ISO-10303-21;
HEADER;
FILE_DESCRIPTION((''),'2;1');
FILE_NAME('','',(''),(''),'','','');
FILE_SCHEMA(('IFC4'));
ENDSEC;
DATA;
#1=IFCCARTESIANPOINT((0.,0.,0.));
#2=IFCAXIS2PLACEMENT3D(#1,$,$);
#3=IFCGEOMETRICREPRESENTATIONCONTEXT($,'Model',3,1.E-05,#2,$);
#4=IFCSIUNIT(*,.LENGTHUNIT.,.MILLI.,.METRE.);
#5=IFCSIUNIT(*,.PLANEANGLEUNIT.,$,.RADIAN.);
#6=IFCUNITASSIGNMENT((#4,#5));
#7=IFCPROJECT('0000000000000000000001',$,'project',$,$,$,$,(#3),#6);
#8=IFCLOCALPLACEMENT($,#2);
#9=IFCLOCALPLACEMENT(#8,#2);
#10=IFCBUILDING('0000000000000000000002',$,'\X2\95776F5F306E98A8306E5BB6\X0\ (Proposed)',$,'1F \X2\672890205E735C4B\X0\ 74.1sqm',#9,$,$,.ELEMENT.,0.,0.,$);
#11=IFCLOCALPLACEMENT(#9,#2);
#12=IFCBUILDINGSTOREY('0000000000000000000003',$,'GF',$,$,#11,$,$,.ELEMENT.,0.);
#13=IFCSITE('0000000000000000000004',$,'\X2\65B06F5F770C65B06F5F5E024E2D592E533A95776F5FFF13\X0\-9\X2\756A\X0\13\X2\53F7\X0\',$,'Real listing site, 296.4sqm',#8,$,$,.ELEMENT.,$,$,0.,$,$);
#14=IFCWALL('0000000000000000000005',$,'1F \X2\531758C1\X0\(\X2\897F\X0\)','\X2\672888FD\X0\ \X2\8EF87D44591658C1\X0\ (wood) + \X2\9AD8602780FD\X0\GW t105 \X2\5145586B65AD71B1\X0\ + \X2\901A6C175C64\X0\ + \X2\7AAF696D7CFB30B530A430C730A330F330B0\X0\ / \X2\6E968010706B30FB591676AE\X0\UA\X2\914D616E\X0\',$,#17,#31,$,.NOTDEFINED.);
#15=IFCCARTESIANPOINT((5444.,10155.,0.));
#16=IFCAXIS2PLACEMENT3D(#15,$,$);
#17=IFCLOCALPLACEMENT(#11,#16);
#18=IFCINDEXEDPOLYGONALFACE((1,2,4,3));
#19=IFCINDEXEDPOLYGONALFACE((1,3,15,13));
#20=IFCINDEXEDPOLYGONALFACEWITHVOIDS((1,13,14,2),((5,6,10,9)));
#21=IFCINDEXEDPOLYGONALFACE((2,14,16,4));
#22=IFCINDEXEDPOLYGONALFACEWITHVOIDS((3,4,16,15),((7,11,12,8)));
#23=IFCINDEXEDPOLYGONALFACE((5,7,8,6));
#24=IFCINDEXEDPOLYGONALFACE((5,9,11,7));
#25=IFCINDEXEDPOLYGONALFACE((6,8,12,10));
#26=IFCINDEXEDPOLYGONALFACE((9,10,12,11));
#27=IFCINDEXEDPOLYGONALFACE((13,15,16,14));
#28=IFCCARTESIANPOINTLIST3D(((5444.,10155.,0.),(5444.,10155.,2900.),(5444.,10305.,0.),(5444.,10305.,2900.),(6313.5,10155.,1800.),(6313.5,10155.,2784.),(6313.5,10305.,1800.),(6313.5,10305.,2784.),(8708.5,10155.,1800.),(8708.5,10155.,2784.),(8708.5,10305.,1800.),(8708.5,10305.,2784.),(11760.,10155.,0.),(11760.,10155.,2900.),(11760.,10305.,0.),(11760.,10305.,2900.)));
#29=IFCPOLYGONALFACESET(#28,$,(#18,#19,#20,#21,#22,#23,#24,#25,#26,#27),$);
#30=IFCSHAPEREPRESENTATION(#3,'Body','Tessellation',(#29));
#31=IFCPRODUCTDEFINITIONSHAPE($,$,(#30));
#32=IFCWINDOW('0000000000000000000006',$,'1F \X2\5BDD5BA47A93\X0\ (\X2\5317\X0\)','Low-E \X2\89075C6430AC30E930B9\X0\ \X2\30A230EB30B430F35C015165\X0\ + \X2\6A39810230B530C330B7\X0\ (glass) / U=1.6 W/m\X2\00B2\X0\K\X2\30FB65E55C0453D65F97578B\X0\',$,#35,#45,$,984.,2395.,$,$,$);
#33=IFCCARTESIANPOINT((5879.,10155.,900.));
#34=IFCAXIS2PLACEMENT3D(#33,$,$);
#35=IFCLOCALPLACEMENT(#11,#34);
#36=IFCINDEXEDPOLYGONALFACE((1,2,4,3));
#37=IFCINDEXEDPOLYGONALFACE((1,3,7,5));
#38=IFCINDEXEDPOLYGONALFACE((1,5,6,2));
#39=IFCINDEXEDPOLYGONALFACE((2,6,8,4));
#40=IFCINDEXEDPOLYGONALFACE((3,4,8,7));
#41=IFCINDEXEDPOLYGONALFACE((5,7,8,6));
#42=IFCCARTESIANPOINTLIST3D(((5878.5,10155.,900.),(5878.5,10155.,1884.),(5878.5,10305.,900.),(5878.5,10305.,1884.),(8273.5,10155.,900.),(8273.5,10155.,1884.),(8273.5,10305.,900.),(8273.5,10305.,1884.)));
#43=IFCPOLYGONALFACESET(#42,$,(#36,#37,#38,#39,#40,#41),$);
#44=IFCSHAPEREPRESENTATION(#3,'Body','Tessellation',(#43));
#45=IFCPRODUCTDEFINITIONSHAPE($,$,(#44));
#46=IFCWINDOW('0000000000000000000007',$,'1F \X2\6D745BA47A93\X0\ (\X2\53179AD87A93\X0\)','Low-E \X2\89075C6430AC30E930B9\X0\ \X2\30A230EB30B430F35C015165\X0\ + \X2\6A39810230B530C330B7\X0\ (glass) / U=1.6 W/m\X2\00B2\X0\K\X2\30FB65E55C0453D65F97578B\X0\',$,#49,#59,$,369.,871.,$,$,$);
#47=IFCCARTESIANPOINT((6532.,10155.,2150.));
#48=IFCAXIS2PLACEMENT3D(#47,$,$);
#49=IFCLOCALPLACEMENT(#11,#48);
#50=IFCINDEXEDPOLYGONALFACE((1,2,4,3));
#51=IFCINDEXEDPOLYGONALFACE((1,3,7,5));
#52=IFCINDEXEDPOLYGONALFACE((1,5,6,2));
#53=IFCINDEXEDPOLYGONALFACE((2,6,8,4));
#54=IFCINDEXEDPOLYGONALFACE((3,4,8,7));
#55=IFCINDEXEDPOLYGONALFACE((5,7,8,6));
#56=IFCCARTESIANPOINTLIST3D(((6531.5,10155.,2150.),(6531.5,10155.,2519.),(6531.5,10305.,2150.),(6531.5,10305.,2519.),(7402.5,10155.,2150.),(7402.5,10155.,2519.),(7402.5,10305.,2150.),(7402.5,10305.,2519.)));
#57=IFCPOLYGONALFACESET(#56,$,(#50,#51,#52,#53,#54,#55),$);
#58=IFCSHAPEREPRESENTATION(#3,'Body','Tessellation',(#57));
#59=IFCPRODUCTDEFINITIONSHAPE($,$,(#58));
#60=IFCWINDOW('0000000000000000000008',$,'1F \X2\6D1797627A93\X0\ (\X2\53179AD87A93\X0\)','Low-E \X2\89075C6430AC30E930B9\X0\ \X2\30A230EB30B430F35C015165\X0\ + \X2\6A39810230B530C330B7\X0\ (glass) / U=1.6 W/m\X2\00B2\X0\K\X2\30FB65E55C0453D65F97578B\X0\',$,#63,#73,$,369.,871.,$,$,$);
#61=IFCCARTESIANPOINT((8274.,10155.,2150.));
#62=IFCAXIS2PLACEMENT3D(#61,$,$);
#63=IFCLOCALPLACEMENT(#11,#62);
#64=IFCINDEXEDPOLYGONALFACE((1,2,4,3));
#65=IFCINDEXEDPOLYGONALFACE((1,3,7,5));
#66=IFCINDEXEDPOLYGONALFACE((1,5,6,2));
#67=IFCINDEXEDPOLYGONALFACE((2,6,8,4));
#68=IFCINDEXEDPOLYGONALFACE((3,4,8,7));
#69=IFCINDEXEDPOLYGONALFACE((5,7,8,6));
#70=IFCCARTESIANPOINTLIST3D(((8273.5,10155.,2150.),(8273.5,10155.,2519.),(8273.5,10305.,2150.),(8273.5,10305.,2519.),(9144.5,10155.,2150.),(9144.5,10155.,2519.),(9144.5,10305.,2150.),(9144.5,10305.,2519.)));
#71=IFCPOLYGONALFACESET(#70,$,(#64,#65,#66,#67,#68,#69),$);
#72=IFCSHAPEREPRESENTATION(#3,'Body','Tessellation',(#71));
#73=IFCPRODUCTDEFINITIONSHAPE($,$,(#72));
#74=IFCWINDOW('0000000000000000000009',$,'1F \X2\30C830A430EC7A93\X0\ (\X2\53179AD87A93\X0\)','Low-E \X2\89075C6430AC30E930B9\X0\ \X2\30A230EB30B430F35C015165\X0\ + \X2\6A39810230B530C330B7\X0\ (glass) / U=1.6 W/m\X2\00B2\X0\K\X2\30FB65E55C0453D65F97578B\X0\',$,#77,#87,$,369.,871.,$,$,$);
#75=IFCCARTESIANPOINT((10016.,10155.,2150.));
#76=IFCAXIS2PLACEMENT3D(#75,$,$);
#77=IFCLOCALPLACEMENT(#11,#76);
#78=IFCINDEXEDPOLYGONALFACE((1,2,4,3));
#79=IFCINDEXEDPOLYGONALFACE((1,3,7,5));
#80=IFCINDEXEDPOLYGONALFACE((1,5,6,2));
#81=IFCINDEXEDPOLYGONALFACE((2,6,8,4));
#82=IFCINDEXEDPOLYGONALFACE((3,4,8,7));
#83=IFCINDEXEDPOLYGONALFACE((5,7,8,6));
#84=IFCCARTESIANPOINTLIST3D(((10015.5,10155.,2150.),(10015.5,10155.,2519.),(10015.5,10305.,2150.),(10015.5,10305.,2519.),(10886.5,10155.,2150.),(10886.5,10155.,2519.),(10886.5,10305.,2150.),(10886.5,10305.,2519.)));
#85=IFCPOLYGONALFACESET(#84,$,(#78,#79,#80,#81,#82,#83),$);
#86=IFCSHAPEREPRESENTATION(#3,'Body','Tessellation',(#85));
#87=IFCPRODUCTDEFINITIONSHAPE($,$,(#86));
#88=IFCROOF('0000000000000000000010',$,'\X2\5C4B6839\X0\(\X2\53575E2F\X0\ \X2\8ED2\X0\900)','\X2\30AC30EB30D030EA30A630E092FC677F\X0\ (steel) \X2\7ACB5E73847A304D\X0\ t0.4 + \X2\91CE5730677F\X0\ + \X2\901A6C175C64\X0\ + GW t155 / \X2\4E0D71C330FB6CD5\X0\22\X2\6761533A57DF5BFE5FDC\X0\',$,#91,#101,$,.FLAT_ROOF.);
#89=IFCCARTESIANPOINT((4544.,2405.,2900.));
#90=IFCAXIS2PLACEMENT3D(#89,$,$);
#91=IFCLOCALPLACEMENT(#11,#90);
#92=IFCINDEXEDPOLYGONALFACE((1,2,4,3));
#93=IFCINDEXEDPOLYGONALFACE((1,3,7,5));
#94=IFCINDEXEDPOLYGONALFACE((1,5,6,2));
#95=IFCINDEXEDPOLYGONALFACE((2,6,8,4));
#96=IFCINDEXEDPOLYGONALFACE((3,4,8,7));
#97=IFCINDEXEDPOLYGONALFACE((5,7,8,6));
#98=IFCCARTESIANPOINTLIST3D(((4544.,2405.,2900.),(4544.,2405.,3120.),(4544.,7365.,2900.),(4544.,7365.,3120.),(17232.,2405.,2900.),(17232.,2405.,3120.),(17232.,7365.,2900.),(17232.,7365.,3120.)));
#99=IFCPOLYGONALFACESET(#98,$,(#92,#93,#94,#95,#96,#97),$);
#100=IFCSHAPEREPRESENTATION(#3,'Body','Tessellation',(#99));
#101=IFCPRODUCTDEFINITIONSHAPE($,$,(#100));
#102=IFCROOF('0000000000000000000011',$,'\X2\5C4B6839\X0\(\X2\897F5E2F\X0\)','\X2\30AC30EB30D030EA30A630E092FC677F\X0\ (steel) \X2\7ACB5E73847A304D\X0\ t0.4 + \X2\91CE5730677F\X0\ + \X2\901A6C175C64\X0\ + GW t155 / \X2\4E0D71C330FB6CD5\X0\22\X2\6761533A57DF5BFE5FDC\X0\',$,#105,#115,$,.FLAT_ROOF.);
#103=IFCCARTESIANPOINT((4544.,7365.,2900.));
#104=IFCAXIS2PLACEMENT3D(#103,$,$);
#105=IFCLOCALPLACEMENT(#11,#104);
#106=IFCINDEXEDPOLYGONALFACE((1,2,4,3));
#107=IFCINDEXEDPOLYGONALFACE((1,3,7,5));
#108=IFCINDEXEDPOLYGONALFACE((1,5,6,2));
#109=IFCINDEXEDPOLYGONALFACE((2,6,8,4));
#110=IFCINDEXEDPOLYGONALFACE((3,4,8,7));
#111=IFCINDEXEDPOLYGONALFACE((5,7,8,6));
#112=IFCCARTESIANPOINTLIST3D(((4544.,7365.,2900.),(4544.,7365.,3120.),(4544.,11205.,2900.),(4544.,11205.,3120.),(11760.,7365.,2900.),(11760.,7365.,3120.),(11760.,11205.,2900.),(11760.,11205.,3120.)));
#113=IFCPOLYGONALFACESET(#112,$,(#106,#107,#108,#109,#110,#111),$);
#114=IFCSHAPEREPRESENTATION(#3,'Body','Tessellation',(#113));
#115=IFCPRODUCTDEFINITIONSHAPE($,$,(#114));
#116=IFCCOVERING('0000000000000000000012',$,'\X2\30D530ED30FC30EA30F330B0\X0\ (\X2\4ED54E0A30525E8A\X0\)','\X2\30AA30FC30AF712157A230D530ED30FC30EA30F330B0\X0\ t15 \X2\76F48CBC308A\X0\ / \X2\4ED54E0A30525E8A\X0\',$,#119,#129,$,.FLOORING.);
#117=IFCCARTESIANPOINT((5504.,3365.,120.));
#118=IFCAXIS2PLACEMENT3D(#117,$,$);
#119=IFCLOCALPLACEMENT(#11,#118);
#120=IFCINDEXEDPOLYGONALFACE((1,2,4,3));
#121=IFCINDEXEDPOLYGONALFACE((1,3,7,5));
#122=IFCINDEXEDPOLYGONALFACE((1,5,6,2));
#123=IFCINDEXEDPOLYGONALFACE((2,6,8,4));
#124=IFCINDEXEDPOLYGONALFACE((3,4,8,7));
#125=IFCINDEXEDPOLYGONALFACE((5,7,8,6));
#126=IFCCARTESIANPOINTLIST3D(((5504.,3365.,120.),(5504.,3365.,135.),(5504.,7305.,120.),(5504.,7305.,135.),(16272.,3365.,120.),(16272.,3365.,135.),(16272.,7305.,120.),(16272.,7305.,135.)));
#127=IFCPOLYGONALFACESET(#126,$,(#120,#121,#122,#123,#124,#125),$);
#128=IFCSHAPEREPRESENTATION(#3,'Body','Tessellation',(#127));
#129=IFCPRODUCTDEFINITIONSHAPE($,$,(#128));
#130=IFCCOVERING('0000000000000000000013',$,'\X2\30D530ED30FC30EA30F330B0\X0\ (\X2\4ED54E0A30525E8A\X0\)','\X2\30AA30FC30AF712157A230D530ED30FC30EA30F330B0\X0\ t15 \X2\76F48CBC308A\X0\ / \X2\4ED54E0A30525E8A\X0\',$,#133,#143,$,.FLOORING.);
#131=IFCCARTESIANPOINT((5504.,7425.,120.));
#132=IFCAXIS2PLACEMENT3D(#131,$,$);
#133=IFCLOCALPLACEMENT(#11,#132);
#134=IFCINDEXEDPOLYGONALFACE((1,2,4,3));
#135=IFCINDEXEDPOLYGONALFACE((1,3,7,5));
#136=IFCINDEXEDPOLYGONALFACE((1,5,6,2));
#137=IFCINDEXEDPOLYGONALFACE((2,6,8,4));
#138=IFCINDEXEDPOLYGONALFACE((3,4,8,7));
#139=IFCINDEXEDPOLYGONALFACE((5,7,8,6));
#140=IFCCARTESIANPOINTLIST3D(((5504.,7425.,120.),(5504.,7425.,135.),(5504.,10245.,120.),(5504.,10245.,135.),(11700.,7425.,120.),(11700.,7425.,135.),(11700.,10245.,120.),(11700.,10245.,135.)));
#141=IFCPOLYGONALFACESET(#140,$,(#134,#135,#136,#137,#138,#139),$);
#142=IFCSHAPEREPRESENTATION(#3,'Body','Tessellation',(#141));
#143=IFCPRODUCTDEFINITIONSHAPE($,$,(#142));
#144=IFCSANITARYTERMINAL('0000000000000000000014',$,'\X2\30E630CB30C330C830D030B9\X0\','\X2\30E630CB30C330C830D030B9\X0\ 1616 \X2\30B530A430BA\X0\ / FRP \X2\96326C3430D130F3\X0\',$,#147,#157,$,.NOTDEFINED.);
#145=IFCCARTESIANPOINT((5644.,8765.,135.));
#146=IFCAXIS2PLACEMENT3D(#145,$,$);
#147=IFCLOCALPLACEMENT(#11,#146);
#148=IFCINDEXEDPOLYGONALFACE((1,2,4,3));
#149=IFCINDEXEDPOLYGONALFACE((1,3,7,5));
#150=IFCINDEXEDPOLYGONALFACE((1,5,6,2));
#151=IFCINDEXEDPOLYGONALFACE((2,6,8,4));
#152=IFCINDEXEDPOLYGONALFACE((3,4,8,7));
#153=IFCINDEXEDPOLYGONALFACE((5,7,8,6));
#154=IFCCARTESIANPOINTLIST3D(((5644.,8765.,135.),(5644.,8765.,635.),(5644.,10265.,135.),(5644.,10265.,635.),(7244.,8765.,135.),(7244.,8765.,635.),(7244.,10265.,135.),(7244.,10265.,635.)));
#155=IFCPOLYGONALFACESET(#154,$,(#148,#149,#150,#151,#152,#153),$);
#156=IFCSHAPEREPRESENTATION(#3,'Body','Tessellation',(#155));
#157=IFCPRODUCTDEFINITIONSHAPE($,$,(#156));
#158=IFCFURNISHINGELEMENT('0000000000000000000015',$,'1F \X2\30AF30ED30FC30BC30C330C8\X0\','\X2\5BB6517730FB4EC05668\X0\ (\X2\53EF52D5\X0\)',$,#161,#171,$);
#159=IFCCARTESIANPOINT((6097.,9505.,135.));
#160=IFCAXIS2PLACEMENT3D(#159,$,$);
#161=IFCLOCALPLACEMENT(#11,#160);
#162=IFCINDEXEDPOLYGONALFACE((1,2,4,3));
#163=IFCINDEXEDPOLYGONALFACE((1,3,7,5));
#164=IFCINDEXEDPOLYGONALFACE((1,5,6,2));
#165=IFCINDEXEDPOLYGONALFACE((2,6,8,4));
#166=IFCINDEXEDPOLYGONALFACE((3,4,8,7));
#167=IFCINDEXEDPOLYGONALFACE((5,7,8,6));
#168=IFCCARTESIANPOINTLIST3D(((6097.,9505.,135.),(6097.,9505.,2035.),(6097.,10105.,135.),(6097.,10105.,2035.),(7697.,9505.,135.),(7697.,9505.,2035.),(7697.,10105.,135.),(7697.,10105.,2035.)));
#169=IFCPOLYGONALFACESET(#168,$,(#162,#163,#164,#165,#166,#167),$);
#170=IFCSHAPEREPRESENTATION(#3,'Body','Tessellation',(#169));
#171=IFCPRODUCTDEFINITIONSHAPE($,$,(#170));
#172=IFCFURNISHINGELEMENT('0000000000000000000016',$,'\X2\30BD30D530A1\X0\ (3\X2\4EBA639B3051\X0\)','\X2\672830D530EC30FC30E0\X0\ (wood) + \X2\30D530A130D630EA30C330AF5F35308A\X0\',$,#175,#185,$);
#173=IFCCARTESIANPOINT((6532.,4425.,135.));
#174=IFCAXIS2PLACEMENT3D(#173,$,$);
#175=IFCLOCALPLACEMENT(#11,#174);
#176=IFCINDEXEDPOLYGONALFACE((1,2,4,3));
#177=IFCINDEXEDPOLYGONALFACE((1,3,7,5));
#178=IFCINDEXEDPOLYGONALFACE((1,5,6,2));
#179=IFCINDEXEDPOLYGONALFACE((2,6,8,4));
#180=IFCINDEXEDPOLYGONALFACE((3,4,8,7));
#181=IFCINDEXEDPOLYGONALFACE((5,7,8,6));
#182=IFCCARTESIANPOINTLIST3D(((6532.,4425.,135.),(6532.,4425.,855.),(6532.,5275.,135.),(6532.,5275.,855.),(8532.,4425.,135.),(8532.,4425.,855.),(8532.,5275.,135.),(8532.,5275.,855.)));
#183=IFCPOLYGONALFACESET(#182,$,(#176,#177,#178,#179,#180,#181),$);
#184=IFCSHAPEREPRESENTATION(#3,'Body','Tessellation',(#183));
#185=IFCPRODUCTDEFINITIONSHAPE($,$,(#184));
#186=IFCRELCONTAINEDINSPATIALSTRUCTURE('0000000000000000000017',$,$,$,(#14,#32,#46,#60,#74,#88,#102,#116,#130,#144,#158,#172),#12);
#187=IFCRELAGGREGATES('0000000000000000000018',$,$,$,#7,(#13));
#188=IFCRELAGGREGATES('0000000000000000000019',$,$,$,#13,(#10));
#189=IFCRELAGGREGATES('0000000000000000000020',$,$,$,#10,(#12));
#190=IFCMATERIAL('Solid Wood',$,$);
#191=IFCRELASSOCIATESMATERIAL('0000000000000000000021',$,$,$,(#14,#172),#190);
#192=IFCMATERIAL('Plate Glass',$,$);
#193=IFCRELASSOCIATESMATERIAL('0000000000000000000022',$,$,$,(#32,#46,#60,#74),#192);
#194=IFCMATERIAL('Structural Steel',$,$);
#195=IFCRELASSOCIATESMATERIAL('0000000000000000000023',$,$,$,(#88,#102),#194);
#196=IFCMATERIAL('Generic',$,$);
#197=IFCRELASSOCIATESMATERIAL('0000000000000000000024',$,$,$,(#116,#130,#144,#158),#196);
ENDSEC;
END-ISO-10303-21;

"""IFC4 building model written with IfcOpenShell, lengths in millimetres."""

from ifc_helpers import new_model, si_unit, frame, frame_2d, origin, place, context, project, spatial, rectangle, extrude, material, element, fill, save


model = new_model("IFC4")

# Units and contexts
model_context = context("Model", 3, precision=1e-05, world=origin())
ifc_project = project(units=[si_unit("LENGTHUNIT", "METRE", prefix="MILLI"), si_unit("PLANEANGLEUNIT", "RADIAN")], contexts=[model_context])

# Site, building, storey
site_placement = place(None, origin())
site = spatial("IfcSite", under=ifc_project, at=site_placement, Name="新潟県新潟市中央区長潟３-9番13号", ObjectType="Real listing site, 296.4sqm", CompositionType="ELEMENT", RefElevation=0.0)
building_placement = place(site_placement, origin())
building = spatial("IfcBuilding", under=site, at=building_placement, Name="長潟の風の家 (Proposed)", ObjectType="1F 木造平屋 74.1sqm", CompositionType="ELEMENT", ElevationOfRefHeight=0.0, ElevationOfTerrain=0.0)
storey_placement = place(building_placement, origin())
storey = spatial("IfcBuildingStorey", under=building, at=storey_placement, Name="GF", CompositionType="ELEMENT", Elevation=0.0)

# Shared definitions
ifc_material_1 = material(Name="Solid Wood")

# Shared definitions
ifc_material_2 = material(Name="Plate Glass")

# Wall, openings, windows
wall_1_placement = place(storey_placement, frame((5444.0, 10155.0, 0.0)))
wall_1 = element("IfcWall", 1, at=wall_1_placement, inside=storey, material=ifc_material_1, Name="1F 北壁(西)", Description="木製 軸組外壁 (wood) + 高性能GW t105 充填断熱 + 通気層 + 窯業系サイディング / 準耐火・外皮UA配慮", PredefinedType="NOTDEFINED", context=model_context, shape_type="SweptSolid", body=[
    extrude(rectangle(XDim=6316.0, YDim=150.0, at=frame_2d((3158.0, 75.0))), frame((5444.0, 10155.0, 0.0)), (0.0, 0.0, 1.0), 2900.0),
])
opening_1_placement = place(storey_placement, frame((5879.0, 10155.0, 900.0)))
opening_1 = element("IfcOpeningElement", 2, at=opening_1_placement, cuts=wall_1, PredefinedType="NOTDEFINED", context=model_context, shape_type="SweptSolid", body=[
    extrude(rectangle(XDim=2395.0, YDim=150.0, at=frame_2d((1197.0, 75.0))), frame((5879.0, 10155.0, 900.0)), (0.0, 0.0, 1.0), 984.0),
])
opening_2_placement = place(storey_placement, frame((6532.0, 10155.0, 2150.0)))
opening_2 = element("IfcOpeningElement", 3, at=opening_2_placement, cuts=wall_1, PredefinedType="NOTDEFINED", context=model_context, shape_type="SweptSolid", body=[
    extrude(rectangle(XDim=871.0, YDim=150.0, at=frame_2d((435.0, 75.0))), frame((6532.0, 10155.0, 2150.0)), (0.0, 0.0, 1.0), 369.0),
])
opening_3_placement = place(storey_placement, frame((8274.0, 10155.0, 2150.0)))
opening_3 = element("IfcOpeningElement", 4, at=opening_3_placement, cuts=wall_1, PredefinedType="NOTDEFINED", context=model_context, shape_type="SweptSolid", body=[
    extrude(rectangle(XDim=871.0, YDim=150.0, at=frame_2d((435.0, 75.0))), frame((8274.0, 10155.0, 2150.0)), (0.0, 0.0, 1.0), 369.0),
])
opening_4_placement = place(storey_placement, frame((10016.0, 10155.0, 2150.0)))
opening_4 = element("IfcOpeningElement", 5, at=opening_4_placement, cuts=wall_1, PredefinedType="NOTDEFINED", context=model_context, shape_type="SweptSolid", body=[
    extrude(rectangle(XDim=871.0, YDim=150.0, at=frame_2d((435.0, 75.0))), frame((10016.0, 10155.0, 2150.0)), (0.0, 0.0, 1.0), 369.0),
])
window_1_placement = place(storey_placement, frame((5879.0, 10155.0, 900.0)))
window_1 = element("IfcWindow", 6, at=window_1_placement, inside=storey, material=ifc_material_2, Name="1F 寝室窓 (北)", Description="Low-E 複層ガラス アルゴン封入 + 樹脂サッシ (glass) / U=1.6 W/m²K・日射取得型", OverallHeight=984.0, OverallWidth=2395.0, context=model_context, shape_type="SweptSolid", body=[
    extrude(rectangle(XDim=2395.0, YDim=150.0, at=frame_2d((1197.0, 75.0))), frame((5879.0, 10155.0, 900.0)), (0.0, 0.0, 1.0), 984.0),
])
fill(opening_1, window_1)
window_2_placement = place(storey_placement, frame((6532.0, 10155.0, 2150.0)))
window_2 = element("IfcWindow", 7, at=window_2_placement, inside=storey, material=ifc_material_2, Name="1F 浴室窓 (北高窓)", Description="Low-E 複層ガラス アルゴン封入 + 樹脂サッシ (glass) / U=1.6 W/m²K・日射取得型", OverallHeight=369.0, OverallWidth=871.0, context=model_context, shape_type="SweptSolid", body=[
    extrude(rectangle(XDim=871.0, YDim=150.0, at=frame_2d((435.0, 75.0))), frame((6532.0, 10155.0, 2150.0)), (0.0, 0.0, 1.0), 369.0),
])
fill(opening_2, window_2)
window_3_placement = place(storey_placement, frame((8274.0, 10155.0, 2150.0)))
window_3 = element("IfcWindow", 8, at=window_3_placement, inside=storey, material=ifc_material_2, Name="1F 洗面窓 (北高窓)", Description="Low-E 複層ガラス アルゴン封入 + 樹脂サッシ (glass) / U=1.6 W/m²K・日射取得型", OverallHeight=369.0, OverallWidth=871.0, context=model_context, shape_type="SweptSolid", body=[
    extrude(rectangle(XDim=871.0, YDim=150.0, at=frame_2d((435.0, 75.0))), frame((8274.0, 10155.0, 2150.0)), (0.0, 0.0, 1.0), 369.0),
])
fill(opening_3, window_3)
window_4_placement = place(storey_placement, frame((10016.0, 10155.0, 2150.0)))
window_4 = element("IfcWindow", 9, at=window_4_placement, inside=storey, material=ifc_material_2, Name="1F トイレ窓 (北高窓)", Description="Low-E 複層ガラス アルゴン封入 + 樹脂サッシ (glass) / U=1.6 W/m²K・日射取得型", OverallHeight=369.0, OverallWidth=871.0, context=model_context, shape_type="SweptSolid", body=[
    extrude(rectangle(XDim=871.0, YDim=150.0, at=frame_2d((435.0, 75.0))), frame((10016.0, 10155.0, 2150.0)), (0.0, 0.0, 1.0), 369.0),
])
fill(opening_4, window_4)

# Roofs
ifc_material_3 = material(Name="Structural Steel")
roof_1_placement = place(storey_placement, frame((4544.0, 2405.0, 2900.0)))
element("IfcRoof", 10, at=roof_1_placement, inside=storey, material=ifc_material_3, Name="屋根(南帯 軒900)", Description="ガルバリウム鋼板 (steel) 立平葺き t0.4 + 野地板 + 通気層 + GW t155 / 不燃・法22条区域対応", PredefinedType="FLAT_ROOF", context=model_context, shape_type="SweptSolid", body=[
    extrude(rectangle(XDim=12688.0, YDim=4960.0, at=frame_2d((6344.0, 2480.0))), frame((4544.0, 2405.0, 2900.0)), (0.0, 0.0, 1.0), 220.0),
])
roof_2_placement = place(storey_placement, frame((4544.0, 7365.0, 2900.0)))
element("IfcRoof", 11, at=roof_2_placement, inside=storey, material=ifc_material_3, Name="屋根(西帯)", Description="ガルバリウム鋼板 (steel) 立平葺き t0.4 + 野地板 + 通気層 + GW t155 / 不燃・法22条区域対応", PredefinedType="FLAT_ROOF", context=model_context, shape_type="SweptSolid", body=[
    extrude(rectangle(XDim=7216.0, YDim=3840.0, at=frame_2d((3608.0, 1920.0))), frame((4544.0, 7365.0, 2900.0)), (0.0, 0.0, 1.0), 220.0),
])

# Coverings
ifc_material_4 = material(Name="Generic")
covering_1_placement = place(storey_placement, frame((5504.0, 3365.0, 120.0)))
element("IfcCovering", 12, at=covering_1_placement, inside=storey, material=ifc_material_4, Name="フローリング (仕上げ床)", Description="オーク無垢フローリング t15 直貼り / 仕上げ床", PredefinedType="FLOORING", context=model_context, shape_type="SweptSolid", body=[
    extrude(rectangle(XDim=10768.0, YDim=3940.0, at=frame_2d((5384.0, 1970.0))), frame((5504.0, 3365.0, 120.0)), (0.0, 0.0, 1.0), 15.0),
])
covering_2_placement = place(storey_placement, frame((5504.0, 7425.0, 120.0)))
element("IfcCovering", 13, at=covering_2_placement, inside=storey, material=ifc_material_4, Name="フローリング (仕上げ床)", Description="オーク無垢フローリング t15 直貼り / 仕上げ床", PredefinedType="FLOORING", context=model_context, shape_type="SweptSolid", body=[
    extrude(rectangle(XDim=6196.0, YDim=2820.0, at=frame_2d((3098.0, 1410.0))), frame((5504.0, 7425.0, 120.0)), (0.0, 0.0, 1.0), 15.0),
])

# Sanitary terminal
sanitary_terminal_placement = place(storey_placement, frame((5644.0, 8765.0, 135.0)))
element("IfcSanitaryTerminal", 14, at=sanitary_terminal_placement, inside=storey, material=ifc_material_4, Name="ユニットバス", Description="ユニットバス 1616 サイズ / FRP 防水パン", PredefinedType="NOTDEFINED", context=model_context, shape_type="SweptSolid", body=[
    extrude(rectangle(XDim=1600.0, YDim=1500.0, at=frame_2d((800.0, 750.0))), frame((5644.0, 8765.0, 135.0)), (0.0, 0.0, 1.0), 500.0),
])

# Furnishing elements
furnishing_1_placement = place(storey_placement, frame((6097.0, 9505.0, 135.0)))
element("IfcFurnishingElement", 15, at=furnishing_1_placement, inside=storey, material=ifc_material_4, Name="1F クローゼット", Description="家具・什器 (可動)", context=model_context, shape_type="SweptSolid", body=[
    extrude(rectangle(XDim=1600.0, YDim=600.0, at=frame_2d((800.0, 300.0))), frame((6097.0, 9505.0, 135.0)), (0.0, 0.0, 1.0), 1900.0),
])
furnishing_2_placement = place(storey_placement, frame((6532.0, 4425.0, 135.0)))
element("IfcFurnishingElement", 16, at=furnishing_2_placement, inside=storey, material=ifc_material_1, Name="ソファ (3人掛け)", Description="木フレーム (wood) + ファブリック張り", context=model_context, shape_type="SweptSolid", body=[
    extrude(rectangle(XDim=2000.0, YDim=850.0, at=frame_2d((1000.0, 425.0))), frame((6532.0, 4425.0, 135.0)), (0.0, 0.0, 1.0), 720.0),
])

save(model, "model.ifc")
